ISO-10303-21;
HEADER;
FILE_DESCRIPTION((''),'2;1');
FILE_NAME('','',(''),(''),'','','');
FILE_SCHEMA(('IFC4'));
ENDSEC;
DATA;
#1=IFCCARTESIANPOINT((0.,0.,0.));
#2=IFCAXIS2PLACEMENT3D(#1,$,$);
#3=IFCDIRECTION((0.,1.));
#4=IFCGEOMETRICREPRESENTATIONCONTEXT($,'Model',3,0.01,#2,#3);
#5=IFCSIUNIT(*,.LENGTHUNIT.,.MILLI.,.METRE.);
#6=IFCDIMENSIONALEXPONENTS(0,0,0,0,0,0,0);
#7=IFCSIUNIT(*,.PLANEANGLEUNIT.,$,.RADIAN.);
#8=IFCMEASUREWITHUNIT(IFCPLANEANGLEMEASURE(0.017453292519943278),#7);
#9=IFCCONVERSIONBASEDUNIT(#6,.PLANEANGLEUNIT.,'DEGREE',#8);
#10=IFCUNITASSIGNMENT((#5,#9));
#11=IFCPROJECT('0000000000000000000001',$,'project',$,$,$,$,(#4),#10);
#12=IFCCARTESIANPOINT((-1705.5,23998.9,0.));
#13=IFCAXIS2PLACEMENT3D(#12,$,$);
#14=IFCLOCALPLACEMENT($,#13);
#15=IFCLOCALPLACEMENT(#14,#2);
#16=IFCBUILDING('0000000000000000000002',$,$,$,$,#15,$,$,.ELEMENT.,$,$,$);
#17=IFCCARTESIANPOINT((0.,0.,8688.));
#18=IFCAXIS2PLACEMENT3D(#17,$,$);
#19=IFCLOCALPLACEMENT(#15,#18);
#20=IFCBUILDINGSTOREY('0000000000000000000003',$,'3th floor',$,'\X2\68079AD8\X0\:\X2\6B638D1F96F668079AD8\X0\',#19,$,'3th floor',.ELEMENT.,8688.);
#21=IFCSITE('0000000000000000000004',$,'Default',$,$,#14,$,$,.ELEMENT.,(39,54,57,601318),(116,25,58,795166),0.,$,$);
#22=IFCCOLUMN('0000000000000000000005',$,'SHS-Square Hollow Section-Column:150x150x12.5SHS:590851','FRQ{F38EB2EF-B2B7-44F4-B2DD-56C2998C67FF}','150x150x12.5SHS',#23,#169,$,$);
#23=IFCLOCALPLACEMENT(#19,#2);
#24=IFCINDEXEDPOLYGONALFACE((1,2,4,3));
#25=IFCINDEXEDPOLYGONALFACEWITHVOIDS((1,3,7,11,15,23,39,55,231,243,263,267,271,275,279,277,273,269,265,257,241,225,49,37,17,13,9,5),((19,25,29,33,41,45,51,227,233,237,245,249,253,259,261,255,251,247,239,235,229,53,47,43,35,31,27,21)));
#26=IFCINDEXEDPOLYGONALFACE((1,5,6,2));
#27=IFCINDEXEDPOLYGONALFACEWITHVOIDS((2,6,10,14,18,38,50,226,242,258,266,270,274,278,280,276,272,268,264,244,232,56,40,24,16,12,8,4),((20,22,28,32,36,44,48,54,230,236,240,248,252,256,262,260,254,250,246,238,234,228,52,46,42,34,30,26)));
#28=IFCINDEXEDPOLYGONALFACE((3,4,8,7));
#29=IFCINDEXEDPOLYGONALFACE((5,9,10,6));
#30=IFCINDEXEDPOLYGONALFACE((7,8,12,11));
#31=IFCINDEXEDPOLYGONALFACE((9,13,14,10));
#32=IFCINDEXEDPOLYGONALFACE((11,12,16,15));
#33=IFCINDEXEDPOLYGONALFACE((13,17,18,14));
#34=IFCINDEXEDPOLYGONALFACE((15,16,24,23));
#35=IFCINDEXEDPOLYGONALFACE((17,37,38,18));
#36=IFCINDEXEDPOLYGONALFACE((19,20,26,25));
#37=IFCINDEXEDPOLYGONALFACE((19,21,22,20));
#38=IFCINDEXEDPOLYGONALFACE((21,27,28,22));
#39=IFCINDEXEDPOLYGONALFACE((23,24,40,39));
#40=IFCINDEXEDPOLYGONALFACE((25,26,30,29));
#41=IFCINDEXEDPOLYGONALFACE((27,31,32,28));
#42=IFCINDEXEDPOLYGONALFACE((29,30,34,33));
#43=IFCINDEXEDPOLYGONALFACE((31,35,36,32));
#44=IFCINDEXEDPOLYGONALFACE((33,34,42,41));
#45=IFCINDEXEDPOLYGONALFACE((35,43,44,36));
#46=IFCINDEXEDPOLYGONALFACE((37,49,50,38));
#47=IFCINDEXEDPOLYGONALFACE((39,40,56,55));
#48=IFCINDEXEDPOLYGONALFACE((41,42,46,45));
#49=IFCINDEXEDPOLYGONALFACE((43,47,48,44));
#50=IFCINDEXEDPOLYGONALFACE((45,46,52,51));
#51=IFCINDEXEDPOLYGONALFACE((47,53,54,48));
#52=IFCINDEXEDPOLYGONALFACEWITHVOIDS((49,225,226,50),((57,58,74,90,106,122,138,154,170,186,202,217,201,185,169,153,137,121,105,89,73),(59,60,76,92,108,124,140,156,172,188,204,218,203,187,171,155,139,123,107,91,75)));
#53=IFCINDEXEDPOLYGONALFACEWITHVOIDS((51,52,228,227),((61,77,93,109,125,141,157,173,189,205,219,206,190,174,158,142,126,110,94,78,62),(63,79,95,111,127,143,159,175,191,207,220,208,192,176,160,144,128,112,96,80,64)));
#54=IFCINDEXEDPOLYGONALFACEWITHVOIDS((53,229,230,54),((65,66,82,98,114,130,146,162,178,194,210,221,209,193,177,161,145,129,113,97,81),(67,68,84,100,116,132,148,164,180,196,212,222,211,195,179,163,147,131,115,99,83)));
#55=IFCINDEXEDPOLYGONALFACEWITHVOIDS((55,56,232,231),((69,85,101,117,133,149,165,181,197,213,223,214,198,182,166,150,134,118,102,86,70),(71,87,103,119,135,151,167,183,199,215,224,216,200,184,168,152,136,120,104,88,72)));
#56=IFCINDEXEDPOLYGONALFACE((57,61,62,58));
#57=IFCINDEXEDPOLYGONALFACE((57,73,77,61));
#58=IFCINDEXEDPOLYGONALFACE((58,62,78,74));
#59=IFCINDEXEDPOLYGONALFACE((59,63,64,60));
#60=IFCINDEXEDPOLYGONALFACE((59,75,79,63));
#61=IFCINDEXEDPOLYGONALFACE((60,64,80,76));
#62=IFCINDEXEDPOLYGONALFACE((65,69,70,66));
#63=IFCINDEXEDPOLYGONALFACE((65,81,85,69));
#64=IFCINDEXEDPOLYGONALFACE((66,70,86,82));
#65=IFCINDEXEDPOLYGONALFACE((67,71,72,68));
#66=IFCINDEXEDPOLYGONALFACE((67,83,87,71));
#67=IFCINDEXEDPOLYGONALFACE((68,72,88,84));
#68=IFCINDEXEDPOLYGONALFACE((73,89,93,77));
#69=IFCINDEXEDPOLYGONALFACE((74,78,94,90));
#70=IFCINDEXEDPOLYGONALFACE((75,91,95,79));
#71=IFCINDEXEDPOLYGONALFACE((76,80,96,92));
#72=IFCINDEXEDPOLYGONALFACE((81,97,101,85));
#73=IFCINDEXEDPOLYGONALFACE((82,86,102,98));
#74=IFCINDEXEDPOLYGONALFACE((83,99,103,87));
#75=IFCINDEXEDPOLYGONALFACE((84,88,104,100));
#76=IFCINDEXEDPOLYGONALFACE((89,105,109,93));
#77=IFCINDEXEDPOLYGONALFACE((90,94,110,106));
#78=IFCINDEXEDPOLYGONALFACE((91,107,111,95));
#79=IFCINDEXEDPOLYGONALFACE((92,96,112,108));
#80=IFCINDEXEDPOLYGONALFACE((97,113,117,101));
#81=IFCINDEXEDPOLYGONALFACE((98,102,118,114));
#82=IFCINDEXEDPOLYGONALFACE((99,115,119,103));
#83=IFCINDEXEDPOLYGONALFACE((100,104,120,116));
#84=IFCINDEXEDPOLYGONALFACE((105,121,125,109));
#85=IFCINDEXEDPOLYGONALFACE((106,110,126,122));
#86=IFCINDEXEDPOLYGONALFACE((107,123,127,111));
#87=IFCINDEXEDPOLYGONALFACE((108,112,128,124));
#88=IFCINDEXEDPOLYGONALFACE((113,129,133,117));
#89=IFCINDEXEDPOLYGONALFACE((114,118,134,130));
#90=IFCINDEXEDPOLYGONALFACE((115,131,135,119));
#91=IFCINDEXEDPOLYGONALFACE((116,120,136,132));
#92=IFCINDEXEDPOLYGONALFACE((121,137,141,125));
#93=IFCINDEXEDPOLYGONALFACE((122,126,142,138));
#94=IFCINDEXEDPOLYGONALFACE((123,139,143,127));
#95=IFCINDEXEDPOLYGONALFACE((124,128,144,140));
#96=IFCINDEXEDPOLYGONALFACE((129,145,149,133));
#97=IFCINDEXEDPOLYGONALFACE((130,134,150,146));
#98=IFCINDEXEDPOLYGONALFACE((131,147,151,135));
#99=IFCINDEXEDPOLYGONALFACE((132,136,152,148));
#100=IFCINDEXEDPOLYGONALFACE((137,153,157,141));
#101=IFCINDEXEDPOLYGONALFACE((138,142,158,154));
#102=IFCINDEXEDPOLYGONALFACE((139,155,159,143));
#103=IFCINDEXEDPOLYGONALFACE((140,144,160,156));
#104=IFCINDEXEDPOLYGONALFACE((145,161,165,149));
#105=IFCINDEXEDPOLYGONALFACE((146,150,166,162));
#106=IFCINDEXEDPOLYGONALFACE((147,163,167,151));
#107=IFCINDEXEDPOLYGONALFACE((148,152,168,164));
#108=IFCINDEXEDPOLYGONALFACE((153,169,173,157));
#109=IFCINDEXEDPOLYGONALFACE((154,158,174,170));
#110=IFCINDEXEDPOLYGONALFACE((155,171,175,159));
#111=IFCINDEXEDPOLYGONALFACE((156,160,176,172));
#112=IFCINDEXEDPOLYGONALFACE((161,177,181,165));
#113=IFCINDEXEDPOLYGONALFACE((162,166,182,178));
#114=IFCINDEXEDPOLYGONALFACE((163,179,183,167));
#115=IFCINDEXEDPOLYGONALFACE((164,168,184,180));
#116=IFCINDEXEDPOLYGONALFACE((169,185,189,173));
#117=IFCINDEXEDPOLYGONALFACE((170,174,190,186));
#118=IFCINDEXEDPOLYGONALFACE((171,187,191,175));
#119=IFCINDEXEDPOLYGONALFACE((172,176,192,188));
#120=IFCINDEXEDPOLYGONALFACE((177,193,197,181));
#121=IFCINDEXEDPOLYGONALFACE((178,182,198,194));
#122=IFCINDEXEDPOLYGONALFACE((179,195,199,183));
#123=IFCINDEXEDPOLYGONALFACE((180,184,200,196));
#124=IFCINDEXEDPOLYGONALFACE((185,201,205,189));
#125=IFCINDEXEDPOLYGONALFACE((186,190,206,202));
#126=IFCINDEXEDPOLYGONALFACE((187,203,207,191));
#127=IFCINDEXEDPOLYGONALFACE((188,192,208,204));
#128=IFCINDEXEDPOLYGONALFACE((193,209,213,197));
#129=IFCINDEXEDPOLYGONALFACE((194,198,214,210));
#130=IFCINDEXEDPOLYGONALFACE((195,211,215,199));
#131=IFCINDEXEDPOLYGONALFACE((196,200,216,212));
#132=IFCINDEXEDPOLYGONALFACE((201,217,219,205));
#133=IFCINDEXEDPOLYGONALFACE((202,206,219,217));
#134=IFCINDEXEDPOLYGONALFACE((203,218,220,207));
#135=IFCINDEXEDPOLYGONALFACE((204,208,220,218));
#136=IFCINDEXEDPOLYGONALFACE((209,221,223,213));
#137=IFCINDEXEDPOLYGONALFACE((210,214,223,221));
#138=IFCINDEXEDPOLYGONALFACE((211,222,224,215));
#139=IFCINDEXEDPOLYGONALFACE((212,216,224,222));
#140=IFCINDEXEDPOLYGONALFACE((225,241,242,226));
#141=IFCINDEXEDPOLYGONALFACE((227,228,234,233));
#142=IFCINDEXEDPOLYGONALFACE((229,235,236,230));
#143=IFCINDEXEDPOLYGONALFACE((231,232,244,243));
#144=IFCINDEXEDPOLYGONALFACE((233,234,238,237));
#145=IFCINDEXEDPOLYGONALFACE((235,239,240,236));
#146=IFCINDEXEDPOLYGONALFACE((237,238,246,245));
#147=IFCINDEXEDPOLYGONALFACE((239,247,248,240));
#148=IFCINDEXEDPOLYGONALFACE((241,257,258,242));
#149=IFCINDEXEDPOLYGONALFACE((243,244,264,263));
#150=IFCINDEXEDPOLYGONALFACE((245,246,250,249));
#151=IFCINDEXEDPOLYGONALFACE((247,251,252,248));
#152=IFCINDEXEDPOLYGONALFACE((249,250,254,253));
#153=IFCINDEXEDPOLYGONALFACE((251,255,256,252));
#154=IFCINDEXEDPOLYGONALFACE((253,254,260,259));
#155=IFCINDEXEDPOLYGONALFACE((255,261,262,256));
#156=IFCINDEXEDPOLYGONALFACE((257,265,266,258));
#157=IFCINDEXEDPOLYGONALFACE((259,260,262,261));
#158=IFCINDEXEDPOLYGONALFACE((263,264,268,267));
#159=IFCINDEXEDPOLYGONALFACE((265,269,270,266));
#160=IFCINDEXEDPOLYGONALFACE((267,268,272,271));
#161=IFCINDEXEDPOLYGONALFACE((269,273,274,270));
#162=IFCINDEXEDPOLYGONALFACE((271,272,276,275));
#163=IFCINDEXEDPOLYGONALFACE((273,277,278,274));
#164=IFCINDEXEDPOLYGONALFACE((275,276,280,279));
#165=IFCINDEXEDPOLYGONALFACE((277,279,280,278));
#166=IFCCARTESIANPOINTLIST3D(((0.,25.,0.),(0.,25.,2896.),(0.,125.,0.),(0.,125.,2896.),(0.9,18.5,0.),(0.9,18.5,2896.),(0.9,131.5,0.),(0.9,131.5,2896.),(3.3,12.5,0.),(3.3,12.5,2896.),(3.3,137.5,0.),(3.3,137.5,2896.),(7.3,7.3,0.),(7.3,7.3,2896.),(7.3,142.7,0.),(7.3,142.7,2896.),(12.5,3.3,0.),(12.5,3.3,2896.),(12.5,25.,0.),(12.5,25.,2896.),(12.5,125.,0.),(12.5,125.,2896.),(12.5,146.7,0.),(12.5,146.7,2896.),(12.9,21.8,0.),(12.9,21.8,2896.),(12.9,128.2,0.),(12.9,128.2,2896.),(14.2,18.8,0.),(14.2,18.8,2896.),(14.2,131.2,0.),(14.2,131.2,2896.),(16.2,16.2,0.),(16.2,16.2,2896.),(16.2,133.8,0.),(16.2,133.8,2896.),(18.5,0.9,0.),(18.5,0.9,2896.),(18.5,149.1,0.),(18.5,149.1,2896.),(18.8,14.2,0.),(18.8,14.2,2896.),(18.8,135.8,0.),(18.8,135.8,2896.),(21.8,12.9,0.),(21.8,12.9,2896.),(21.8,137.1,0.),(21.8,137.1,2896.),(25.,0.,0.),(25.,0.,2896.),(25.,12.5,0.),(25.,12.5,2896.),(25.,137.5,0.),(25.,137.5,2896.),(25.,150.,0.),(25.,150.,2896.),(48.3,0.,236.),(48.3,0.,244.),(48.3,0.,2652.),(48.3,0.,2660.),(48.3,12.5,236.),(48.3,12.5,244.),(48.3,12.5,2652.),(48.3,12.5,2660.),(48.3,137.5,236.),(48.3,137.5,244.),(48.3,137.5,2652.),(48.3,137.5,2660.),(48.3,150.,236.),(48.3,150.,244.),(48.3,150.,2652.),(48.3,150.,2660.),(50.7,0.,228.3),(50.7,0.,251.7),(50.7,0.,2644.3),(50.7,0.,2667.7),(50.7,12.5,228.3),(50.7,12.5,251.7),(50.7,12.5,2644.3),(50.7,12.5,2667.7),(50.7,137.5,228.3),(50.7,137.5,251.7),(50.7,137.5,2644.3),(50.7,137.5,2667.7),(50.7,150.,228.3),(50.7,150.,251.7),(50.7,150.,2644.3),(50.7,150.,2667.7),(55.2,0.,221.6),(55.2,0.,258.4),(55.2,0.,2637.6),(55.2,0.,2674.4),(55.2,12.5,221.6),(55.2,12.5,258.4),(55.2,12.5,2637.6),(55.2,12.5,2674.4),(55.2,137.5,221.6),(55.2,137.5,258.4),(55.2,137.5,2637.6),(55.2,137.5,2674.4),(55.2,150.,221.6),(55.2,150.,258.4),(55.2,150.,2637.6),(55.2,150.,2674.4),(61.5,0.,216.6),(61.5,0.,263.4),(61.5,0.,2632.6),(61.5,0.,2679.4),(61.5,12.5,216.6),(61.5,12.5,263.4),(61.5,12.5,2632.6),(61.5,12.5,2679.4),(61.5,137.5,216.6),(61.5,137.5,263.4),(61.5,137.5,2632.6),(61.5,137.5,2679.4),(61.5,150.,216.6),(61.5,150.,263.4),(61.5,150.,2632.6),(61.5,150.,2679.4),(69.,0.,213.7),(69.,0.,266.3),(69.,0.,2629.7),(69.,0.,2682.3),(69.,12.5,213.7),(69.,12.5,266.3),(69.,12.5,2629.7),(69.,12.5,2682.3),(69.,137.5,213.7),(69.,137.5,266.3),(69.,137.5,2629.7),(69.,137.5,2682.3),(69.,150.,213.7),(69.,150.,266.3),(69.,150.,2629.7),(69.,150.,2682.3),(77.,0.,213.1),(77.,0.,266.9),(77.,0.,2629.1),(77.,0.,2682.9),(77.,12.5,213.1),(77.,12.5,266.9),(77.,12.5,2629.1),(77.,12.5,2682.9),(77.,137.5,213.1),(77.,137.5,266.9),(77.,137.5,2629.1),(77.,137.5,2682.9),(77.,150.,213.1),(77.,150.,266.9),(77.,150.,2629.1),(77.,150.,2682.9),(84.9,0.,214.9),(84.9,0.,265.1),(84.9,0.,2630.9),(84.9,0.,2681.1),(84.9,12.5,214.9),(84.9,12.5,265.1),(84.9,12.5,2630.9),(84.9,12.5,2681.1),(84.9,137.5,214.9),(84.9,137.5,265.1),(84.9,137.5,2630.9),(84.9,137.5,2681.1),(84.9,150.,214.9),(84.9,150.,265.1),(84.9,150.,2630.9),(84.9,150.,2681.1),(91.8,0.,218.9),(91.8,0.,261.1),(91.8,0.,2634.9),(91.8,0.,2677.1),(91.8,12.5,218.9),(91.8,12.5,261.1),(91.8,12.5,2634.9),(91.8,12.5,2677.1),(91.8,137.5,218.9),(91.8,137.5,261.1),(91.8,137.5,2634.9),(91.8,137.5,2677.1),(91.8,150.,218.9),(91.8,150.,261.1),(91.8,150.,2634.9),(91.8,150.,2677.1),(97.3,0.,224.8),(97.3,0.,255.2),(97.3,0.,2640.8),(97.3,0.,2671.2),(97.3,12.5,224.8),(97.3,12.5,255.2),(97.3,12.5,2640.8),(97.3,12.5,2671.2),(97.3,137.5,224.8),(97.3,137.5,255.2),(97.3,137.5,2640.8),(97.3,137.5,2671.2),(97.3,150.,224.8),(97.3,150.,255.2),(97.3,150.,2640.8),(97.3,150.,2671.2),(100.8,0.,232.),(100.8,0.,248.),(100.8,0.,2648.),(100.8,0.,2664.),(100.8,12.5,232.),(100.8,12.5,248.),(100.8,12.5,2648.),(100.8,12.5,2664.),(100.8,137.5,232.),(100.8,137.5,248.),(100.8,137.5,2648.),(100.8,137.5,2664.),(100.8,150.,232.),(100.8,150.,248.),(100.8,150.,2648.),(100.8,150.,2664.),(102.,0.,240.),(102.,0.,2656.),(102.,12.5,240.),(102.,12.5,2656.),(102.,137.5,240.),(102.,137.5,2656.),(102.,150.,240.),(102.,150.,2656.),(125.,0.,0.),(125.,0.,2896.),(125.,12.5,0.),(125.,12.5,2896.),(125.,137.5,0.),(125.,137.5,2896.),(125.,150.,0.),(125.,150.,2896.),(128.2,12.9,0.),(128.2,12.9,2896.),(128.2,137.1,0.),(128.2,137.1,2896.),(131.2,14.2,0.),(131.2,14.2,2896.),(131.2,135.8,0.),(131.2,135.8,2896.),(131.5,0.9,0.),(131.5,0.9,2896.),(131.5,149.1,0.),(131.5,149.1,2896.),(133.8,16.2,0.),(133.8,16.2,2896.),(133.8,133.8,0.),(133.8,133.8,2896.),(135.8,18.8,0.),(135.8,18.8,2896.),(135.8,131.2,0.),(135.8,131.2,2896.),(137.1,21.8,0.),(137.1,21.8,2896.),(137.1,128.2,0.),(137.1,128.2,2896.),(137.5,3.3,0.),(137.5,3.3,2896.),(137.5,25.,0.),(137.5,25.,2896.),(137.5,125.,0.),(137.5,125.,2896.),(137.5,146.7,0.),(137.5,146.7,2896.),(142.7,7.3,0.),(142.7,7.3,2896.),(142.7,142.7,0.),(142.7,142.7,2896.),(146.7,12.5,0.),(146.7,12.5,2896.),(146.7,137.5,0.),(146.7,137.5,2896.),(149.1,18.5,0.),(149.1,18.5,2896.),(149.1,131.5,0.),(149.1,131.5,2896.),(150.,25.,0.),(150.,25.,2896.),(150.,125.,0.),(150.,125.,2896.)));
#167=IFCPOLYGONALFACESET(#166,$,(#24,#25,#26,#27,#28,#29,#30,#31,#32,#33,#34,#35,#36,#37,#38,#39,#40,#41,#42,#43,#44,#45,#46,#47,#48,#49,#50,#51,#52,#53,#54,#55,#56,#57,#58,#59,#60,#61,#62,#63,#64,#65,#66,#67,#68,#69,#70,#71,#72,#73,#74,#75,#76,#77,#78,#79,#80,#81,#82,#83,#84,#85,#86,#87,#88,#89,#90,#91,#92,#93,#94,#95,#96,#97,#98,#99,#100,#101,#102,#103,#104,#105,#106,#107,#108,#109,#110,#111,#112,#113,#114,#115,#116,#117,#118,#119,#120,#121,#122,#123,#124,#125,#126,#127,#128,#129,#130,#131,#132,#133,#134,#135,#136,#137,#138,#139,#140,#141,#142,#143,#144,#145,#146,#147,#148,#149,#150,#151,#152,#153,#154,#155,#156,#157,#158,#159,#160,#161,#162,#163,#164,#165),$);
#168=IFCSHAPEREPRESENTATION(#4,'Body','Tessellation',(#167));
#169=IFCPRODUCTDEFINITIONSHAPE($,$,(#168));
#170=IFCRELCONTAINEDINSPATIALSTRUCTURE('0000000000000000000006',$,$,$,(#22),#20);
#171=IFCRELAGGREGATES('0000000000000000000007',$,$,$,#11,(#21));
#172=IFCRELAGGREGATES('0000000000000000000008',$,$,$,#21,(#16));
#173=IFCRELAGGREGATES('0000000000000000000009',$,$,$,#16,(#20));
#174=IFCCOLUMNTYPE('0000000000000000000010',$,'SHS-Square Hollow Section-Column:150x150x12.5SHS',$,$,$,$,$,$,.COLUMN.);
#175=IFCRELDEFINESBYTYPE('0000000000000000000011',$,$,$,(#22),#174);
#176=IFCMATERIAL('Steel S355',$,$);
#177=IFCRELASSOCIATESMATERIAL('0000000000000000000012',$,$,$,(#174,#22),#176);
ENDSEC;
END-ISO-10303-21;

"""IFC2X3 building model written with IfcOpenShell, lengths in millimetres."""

from ifc_helpers import new_model, entity, si_unit, converted_unit, direction, frame, frame_2d, origin, origin_2d, place, context, project, spatial, circle_curve, hollow_rectangle, outline, extrude, material, type_object, element, save


model = new_model("IFC2X3")

# Units and contexts
model_context = context("Model", 3, precision=0.01, world=origin(), true_north=direction((0.0, 1.0)))
ifc_project = project(units=[si_unit("LENGTHUNIT", "METRE", prefix="MILLI"), converted_unit("PLANEANGLEUNIT", "DEGREE", entity("IfcPlaneAngleMeasure", 0.017453292519943278), si_unit("PLANEANGLEUNIT", "RADIAN"), dimensions=[0, 0, 0, 0, 0, 0, 0])], contexts=[model_context])

# Site, building, storey
site_placement = place(None, frame((-1705.5, 23998.9, 0.0)))
site = spatial("IfcSite", under=ifc_project, at=site_placement, Name="Default", CompositionType="ELEMENT", RefLatitude=(39, 54, 57, 601318), RefLongitude=(116, 25, 58, 795166), RefElevation=0.0)
building_placement = place(site_placement, origin())
building = spatial("IfcBuilding", under=site, at=building_placement, CompositionType="ELEMENT")
storey_placement = place(building_placement, frame((0.0, 0.0, 8688.0)))
storey = spatial("IfcBuildingStorey", under=building, at=storey_placement, Name="3th floor", ObjectType="标高:正负零标高", LongName="3th floor", CompositionType="ELEMENT", Elevation=8688.0)

# Column, openings
ifc_material_1 = material(Name="Steel S355")
column_type_1 = type_object("IfcColumnType", Name="SHS-Square Hollow Section-Column:150x150x12.5SHS", PredefinedType="COLUMN", material=ifc_material_1)
column_1_placement = place(storey_placement, frame((75.0, 75.0, 2896.0), z_axis=(0.0, 0.0, 1.0), x_axis=(0.0, -1.0, 0.0)))
column_1 = element("IfcColumn", 1, at=column_1_placement, inside=storey, type_object=column_type_1, material=ifc_material_1, Name="SHS-Square Hollow Section-Column:150x150x12.5SHS:590851", Description="FRQ{F38EB2EF-B2B7-44F4-B2DD-56C2998C67FF}", ObjectType="150x150x12.5SHS", context=model_context, shape_type="SweptSolid", body=[
    extrude(hollow_rectangle(XDim=150.0, YDim=150.0, WallThickness=12.5, InnerFilletRadius=12.5, OuterFilletRadius=25.0, at=origin_2d()), origin(), (0.0, 0.0, -1.0), 2896.0),
])
opening_1_placement = place(column_1_placement, frame((-175.1, 0.0, -2896.0), z_axis=(1.0, 0.0, 0.0), x_axis=(0.0, 1.0, 0.0)))
element("IfcOpeningElement", 2, at=opening_1_placement, cuts=column_1, ObjectType="Opening", context=model_context, shape_type="SweptSolid", body=[
    extrude(outline(circle_curve(frame_2d((0.0, 240.0), x_axis=(1.0, 0.0)), 27.0)), origin(), (0.0, 0.0, 1.0), 350.2),
])
opening_2_placement = place(column_1_placement, frame((-175.1, 0.0, 0.0), z_axis=(1.0, 0.0, 0.0), x_axis=(0.0, 1.0, 0.0)))
element("IfcOpeningElement", 3, at=opening_2_placement, cuts=column_1, ObjectType="Opening", context=model_context, shape_type="SweptSolid", body=[
    extrude(outline(circle_curve(frame_2d((0.0, -240.0), x_axis=(1.0, 0.0)), 27.0)), origin(), (0.0, 0.0, 1.0), 350.2),
])

save(model, "model.ifc")
